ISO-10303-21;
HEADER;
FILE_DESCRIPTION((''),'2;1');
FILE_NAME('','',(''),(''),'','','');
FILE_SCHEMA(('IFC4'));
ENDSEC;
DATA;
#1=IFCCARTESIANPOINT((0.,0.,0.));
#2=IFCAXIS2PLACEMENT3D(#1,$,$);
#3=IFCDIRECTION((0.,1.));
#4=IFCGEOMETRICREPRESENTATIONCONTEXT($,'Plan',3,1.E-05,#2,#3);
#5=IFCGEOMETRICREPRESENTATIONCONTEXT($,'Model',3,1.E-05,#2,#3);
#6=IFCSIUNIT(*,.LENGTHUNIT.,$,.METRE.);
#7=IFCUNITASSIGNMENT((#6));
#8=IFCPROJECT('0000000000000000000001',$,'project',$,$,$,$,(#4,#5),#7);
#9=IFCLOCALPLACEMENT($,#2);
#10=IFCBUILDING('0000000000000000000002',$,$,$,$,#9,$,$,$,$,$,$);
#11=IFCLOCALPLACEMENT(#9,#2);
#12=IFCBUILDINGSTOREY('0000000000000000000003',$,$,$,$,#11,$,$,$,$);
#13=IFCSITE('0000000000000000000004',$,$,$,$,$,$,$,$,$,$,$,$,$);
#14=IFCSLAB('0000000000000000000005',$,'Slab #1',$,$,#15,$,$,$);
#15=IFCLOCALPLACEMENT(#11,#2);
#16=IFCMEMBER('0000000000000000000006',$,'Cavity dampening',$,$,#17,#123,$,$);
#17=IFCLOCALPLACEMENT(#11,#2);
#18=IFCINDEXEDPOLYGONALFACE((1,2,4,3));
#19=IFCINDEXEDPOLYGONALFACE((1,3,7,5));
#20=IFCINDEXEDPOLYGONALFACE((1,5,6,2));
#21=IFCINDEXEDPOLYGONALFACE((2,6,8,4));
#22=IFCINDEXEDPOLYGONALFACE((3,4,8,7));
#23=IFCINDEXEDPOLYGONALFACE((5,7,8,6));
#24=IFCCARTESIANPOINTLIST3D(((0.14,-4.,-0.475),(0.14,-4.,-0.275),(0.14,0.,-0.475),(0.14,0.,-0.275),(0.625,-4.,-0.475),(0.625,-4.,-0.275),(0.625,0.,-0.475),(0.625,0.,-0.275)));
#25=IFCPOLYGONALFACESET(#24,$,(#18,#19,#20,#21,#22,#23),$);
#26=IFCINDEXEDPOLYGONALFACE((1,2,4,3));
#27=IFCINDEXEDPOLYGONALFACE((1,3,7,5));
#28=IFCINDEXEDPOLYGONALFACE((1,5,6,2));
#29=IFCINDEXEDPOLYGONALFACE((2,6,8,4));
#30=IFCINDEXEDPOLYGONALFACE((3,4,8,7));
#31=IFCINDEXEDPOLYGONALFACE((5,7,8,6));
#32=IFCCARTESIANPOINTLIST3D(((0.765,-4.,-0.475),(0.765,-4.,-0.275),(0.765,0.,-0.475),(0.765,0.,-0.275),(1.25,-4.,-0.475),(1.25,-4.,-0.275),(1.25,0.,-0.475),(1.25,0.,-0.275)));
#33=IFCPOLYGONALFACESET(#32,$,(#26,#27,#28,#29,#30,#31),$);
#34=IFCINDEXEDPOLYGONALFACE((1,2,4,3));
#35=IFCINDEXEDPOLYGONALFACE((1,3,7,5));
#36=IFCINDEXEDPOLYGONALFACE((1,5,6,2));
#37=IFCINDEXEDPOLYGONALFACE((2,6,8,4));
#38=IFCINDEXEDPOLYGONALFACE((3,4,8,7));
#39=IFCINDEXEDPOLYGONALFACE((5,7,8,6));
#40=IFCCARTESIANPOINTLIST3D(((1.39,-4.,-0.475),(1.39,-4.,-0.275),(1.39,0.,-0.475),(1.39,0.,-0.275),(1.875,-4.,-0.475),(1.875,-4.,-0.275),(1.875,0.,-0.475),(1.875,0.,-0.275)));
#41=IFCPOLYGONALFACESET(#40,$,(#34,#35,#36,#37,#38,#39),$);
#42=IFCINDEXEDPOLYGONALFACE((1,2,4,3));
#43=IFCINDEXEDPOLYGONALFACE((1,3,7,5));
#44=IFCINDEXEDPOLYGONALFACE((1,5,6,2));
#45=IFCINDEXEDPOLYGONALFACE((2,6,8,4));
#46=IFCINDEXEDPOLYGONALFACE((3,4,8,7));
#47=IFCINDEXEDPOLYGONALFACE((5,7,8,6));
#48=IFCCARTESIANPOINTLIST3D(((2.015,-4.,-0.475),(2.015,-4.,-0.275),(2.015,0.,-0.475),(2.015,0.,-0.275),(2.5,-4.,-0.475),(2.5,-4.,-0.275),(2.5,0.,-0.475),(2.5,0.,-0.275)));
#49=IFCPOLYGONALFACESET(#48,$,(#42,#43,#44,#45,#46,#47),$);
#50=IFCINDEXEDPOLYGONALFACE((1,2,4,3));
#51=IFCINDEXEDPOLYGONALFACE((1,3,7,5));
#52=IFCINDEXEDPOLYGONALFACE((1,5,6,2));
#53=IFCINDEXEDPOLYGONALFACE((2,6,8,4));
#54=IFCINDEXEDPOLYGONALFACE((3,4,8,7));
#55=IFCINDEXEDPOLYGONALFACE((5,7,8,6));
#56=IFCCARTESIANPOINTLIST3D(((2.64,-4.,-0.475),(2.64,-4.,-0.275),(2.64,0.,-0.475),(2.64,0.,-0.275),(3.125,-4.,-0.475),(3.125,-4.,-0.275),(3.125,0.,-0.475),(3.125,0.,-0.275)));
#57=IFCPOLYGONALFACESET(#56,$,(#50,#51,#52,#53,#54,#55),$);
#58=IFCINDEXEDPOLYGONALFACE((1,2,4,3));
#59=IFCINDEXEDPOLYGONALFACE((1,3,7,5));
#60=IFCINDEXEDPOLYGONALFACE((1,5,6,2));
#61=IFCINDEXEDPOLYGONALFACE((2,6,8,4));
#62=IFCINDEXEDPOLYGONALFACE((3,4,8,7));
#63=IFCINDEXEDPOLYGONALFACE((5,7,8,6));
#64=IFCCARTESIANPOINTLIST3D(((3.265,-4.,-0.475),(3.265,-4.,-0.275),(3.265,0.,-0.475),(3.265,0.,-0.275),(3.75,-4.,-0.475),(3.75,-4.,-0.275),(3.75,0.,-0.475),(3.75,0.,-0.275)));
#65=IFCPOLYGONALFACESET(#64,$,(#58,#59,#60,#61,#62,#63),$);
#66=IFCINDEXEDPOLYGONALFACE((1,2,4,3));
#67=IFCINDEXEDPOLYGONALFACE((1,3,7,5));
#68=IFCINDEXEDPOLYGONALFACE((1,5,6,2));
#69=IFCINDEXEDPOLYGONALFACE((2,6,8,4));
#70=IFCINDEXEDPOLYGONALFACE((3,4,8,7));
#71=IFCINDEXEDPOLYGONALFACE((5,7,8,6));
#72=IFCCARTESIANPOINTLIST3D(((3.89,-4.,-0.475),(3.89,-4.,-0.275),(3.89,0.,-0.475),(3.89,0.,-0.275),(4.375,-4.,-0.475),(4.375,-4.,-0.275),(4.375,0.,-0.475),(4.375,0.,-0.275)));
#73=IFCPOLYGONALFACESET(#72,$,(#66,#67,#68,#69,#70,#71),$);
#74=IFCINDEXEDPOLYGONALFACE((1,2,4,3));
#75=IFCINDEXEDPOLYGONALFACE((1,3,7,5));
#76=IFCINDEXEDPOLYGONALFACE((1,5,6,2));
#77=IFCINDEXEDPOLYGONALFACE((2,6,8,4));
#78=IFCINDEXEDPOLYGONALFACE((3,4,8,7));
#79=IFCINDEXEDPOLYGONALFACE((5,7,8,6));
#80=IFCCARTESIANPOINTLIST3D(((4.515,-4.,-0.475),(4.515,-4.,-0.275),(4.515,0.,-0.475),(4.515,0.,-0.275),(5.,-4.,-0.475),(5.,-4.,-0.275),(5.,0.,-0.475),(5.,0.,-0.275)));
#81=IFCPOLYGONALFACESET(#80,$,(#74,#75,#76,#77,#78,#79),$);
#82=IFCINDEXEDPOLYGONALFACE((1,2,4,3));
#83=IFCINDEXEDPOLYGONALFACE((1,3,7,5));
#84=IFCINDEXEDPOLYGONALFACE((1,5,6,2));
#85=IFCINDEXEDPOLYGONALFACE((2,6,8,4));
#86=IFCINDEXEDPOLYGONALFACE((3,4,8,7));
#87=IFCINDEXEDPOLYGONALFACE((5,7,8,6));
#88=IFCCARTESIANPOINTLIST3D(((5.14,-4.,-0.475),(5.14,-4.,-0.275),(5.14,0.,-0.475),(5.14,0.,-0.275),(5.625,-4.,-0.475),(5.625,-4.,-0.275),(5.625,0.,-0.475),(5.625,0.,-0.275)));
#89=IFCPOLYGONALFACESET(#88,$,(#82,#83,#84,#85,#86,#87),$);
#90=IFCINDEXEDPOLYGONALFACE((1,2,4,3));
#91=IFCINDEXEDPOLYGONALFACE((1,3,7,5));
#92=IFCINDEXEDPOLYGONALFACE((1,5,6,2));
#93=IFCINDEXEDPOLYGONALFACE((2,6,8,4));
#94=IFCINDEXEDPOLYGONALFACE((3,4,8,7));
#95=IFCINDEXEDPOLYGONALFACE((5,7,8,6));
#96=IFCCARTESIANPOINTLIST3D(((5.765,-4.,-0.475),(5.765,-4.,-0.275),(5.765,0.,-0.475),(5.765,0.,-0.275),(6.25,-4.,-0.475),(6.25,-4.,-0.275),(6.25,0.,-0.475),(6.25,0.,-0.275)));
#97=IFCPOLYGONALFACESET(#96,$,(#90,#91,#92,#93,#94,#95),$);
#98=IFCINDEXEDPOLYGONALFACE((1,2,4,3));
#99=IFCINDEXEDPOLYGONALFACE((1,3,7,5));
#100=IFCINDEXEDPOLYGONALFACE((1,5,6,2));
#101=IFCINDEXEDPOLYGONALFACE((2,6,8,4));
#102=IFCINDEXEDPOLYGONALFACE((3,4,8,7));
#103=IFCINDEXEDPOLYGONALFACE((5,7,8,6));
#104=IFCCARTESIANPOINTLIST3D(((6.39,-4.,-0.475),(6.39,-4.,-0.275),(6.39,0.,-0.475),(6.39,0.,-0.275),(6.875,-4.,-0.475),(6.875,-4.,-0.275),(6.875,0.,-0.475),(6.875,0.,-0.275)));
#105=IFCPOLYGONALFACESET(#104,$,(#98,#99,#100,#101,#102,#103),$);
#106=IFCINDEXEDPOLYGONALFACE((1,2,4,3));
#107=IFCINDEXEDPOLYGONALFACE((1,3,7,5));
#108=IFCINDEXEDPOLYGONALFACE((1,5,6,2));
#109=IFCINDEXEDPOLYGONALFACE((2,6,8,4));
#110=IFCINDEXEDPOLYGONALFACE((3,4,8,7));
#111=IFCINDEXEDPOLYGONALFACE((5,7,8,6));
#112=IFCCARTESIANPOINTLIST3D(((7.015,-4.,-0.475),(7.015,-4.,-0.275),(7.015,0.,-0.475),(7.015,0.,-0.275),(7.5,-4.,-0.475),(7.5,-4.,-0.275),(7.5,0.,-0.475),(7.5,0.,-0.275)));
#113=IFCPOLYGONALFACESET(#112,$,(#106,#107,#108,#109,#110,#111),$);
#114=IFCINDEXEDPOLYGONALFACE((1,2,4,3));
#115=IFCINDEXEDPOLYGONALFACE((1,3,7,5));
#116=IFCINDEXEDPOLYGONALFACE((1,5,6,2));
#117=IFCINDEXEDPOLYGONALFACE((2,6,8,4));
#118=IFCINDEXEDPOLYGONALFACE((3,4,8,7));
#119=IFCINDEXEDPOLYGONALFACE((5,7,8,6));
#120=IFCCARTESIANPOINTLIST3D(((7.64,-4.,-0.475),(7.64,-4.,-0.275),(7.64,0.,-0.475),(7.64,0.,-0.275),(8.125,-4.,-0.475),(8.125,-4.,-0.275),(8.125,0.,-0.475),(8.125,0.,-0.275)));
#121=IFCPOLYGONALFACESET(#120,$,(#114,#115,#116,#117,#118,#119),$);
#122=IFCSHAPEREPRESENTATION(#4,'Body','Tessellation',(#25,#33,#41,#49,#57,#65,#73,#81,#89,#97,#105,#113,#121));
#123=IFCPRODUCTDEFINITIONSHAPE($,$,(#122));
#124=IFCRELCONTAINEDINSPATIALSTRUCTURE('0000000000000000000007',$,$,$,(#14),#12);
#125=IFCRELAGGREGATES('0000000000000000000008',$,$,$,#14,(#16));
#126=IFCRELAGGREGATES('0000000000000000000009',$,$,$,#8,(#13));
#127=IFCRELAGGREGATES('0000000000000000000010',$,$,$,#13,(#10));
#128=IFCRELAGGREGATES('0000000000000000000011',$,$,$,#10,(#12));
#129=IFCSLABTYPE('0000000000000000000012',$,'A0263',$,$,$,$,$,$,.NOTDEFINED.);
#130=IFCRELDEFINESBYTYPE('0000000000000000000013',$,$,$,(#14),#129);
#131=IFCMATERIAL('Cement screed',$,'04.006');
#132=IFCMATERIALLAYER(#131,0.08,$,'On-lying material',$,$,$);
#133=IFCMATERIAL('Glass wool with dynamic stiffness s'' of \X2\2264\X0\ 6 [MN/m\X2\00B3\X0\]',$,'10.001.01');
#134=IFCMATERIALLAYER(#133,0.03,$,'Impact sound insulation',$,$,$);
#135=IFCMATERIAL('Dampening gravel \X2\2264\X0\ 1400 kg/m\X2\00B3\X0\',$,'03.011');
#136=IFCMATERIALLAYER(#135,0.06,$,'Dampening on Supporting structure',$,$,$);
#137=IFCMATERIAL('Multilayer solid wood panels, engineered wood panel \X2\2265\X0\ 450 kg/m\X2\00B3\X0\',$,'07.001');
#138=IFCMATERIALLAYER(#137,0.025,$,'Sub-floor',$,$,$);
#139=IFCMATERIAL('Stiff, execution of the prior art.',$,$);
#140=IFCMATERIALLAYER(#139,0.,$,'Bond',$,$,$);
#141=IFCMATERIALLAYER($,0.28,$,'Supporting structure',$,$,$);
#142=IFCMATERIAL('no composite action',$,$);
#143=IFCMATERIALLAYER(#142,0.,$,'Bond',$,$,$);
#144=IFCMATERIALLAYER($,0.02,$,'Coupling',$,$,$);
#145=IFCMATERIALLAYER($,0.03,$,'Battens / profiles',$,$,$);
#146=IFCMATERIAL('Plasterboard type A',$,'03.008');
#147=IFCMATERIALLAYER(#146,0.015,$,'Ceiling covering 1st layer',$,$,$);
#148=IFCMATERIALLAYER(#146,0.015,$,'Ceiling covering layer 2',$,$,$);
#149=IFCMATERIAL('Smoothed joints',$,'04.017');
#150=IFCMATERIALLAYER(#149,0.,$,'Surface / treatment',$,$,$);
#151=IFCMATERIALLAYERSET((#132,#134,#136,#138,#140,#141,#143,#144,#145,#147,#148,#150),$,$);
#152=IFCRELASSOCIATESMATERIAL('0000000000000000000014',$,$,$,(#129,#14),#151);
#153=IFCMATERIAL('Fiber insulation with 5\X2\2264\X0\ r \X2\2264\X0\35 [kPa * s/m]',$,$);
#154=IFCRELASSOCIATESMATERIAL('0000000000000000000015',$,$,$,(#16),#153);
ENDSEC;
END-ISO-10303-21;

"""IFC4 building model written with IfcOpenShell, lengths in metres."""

from ifc_helpers import new_model, si_unit, direction, frame, frame_2d, origin, place, context, project, spatial, rectangle, extrude, material, layer, layer_set, type_object, element, aggregate, save


model = new_model("IFC4")

# Units and contexts
plan_context = context("Plan", 3, precision=1e-05, world=origin(), true_north=direction((0.0, 1.0)))
model_context = context("Model", 3, precision=1e-05, world=origin(), true_north=direction((0.0, 1.0)))
ifc_project = project(units=[si_unit("LENGTHUNIT", "METRE")], contexts=[plan_context, model_context])

# Site, building, storey
site = spatial("IfcSite", under=ifc_project)
building_placement = place(None, origin())
building = spatial("IfcBuilding", under=site, at=building_placement)
storey_placement = place(building_placement, origin())
storey = spatial("IfcBuildingStorey", under=building, at=storey_placement)

# Slab, member
ifc_material_1 = material(Name="Cement screed", Category="04.006")
ifc_layer_1 = layer(ifc_material_1, 0.08, Name="On-lying material")
ifc_material_2 = material(Name="Glass wool with dynamic stiffness s' of ≤ 6 [MN/m³]", Category="10.001.01")
ifc_layer_2 = layer(ifc_material_2, 0.03, Name="Impact sound insulation")
ifc_material_3 = material(Name="Dampening gravel ≤ 1400 kg/m³", Category="03.011")
ifc_layer_3 = layer(ifc_material_3, 0.06, Name="Dampening on Supporting structure")
ifc_material_4 = material(Name="Multilayer solid wood panels, engineered wood panel ≥ 450 kg/m³", Category="07.001")
ifc_layer_4 = layer(ifc_material_4, 0.025, Name="Sub-floor")
ifc_material_5 = material(Name="Stiff, execution of the prior art.")
ifc_layer_5 = layer(ifc_material_5, 0.0, Name="Bond")
ifc_layer_6 = layer(None, 0.28, Name="Supporting structure")
ifc_material_6 = material(Name="no composite action")
ifc_layer_7 = layer(ifc_material_6, 0.0, Name="Bond")
ifc_layer_8 = layer(None, 0.02, Name="Coupling")
ifc_layer_9 = layer(None, 0.03, Name="Battens / profiles")
ifc_material_7 = material(Name="Plasterboard type A", Category="03.008")
ifc_layer_10 = layer(ifc_material_7, 0.015, Name="Ceiling covering 1st layer")
ifc_layer_11 = layer(ifc_material_7, 0.015, Name="Ceiling covering layer 2")
ifc_material_8 = material(Name="Smoothed joints", Category="04.017")
ifc_layer_12 = layer(ifc_material_8, 0.0, Name="Surface / treatment")
ifc_layer_set = layer_set([ifc_layer_1, ifc_layer_2, ifc_layer_3, ifc_layer_4, ifc_layer_5, ifc_layer_6, ifc_layer_7, ifc_layer_8, ifc_layer_9, ifc_layer_10, ifc_layer_11, ifc_layer_12])
slab_type = type_object("IfcSlabType", Name="A0263", PredefinedType="NOTDEFINED", material=ifc_layer_set)
slab_placement = place(None, frame((0.0, 0.0, 0.0), z_axis=(0.0, 0.0, -1.0), x_axis=(1.0, 0.0, 0.0)))
slab = element("IfcSlab", 1, at=slab_placement, inside=storey, type_object=slab_type, material=ifc_layer_set, Name="Slab #1")
ifc_material_9 = material(Name="Fiber insulation with 5≤ r ≤35 [kPa * s/m]")
member_1_placement = place(slab_placement, origin())
member_1 = element("IfcMember", 2, at=member_1_placement, material=ifc_material_9, Name="Cavity dampening", context=plan_context, shape_type="SweptSolid", body=[
    extrude(rectangle(XDim=0.485, YDim=0.2, at=frame_2d((0.2425, 0.1), x_axis=(1.0, 0.0))), frame((0.14, 4.0, 0.275), z_axis=(0.0, -1.0, 0.0), x_axis=(1.0, 0.0, 0.0)), (0.0, 0.0, 1.0), 4.0),
    extrude(rectangle(XDim=0.485, YDim=0.2, at=frame_2d((0.2425, 0.1), x_axis=(1.0, 0.0))), frame((0.765, 4.0, 0.275), z_axis=(0.0, -1.0, 0.0), x_axis=(1.0, 0.0, 0.0)), (0.0, 0.0, 1.0), 4.0),
    extrude(rectangle(XDim=0.485, YDim=0.2, at=frame_2d((0.2425, 0.1), x_axis=(1.0, 0.0))), frame((1.39, 4.0, 0.275), z_axis=(0.0, -1.0, 0.0), x_axis=(1.0, 0.0, 0.0)), (0.0, 0.0, 1.0), 4.0),
    extrude(rectangle(XDim=0.485, YDim=0.2, at=frame_2d((0.2425, 0.1), x_axis=(1.0, 0.0))), frame((2.015, 4.0, 0.275), z_axis=(0.0, -1.0, 0.0), x_axis=(1.0, 0.0, 0.0)), (0.0, 0.0, 1.0), 4.0),
    extrude(rectangle(XDim=0.485, YDim=0.2, at=frame_2d((0.2425, 0.1), x_axis=(1.0, 0.0))), frame((2.64, 4.0, 0.275), z_axis=(0.0, -1.0, 0.0), x_axis=(1.0, 0.0, 0.0)), (0.0, 0.0, 1.0), 4.0),
    extrude(rectangle(XDim=0.485, YDim=0.2, at=frame_2d((0.2425, 0.1), x_axis=(1.0, 0.0))), frame((3.265, 4.0, 0.275), z_axis=(0.0, -1.0, 0.0), x_axis=(1.0, 0.0, 0.0)), (0.0, 0.0, 1.0), 4.0),
    extrude(rectangle(XDim=0.485, YDim=0.2, at=frame_2d((0.2425, 0.1), x_axis=(1.0, 0.0))), frame((3.89, 4.0, 0.275), z_axis=(0.0, -1.0, 0.0), x_axis=(1.0, 0.0, 0.0)), (0.0, 0.0, 1.0), 4.0),
    extrude(rectangle(XDim=0.485, YDim=0.2, at=frame_2d((0.2425, 0.1), x_axis=(1.0, 0.0))), frame((4.515, 4.0, 0.275), z_axis=(0.0, -1.0, 0.0), x_axis=(1.0, 0.0, 0.0)), (0.0, 0.0, 1.0), 4.0),
    extrude(rectangle(XDim=0.485, YDim=0.2, at=frame_2d((0.2425, 0.1), x_axis=(1.0, 0.0))), frame((5.14, 4.0, 0.275), z_axis=(0.0, -1.0, 0.0), x_axis=(1.0, 0.0, 0.0)), (0.0, 0.0, 1.0), 4.0),
    extrude(rectangle(XDim=0.485, YDim=0.2, at=frame_2d((0.2425, 0.1), x_axis=(1.0, 0.0))), frame((5.765, 4.0, 0.275), z_axis=(0.0, -1.0, 0.0), x_axis=(1.0, 0.0, 0.0)), (0.0, 0.0, 1.0), 4.0),
    extrude(rectangle(XDim=0.485, YDim=0.2, at=frame_2d((0.2425, 0.1), x_axis=(1.0, 0.0))), frame((6.39, 4.0, 0.275), z_axis=(0.0, -1.0, 0.0), x_axis=(1.0, 0.0, 0.0)), (0.0, 0.0, 1.0), 4.0),
    extrude(rectangle(XDim=0.485, YDim=0.2, at=frame_2d((0.2425, 0.1), x_axis=(1.0, 0.0))), frame((7.015, 4.0, 0.275), z_axis=(0.0, -1.0, 0.0), x_axis=(1.0, 0.0, 0.0)), (0.0, 0.0, 1.0), 4.0),
    extrude(rectangle(XDim=0.485, YDim=0.2, at=frame_2d((0.2425, 0.1), x_axis=(1.0, 0.0))), frame((7.64, 4.0, 0.275), z_axis=(0.0, -1.0, 0.0), x_axis=(1.0, 0.0, 0.0)), (0.0, 0.0, 1.0), 4.0),
])
aggregate(slab, [member_1])

save(model, "model.ifc")
